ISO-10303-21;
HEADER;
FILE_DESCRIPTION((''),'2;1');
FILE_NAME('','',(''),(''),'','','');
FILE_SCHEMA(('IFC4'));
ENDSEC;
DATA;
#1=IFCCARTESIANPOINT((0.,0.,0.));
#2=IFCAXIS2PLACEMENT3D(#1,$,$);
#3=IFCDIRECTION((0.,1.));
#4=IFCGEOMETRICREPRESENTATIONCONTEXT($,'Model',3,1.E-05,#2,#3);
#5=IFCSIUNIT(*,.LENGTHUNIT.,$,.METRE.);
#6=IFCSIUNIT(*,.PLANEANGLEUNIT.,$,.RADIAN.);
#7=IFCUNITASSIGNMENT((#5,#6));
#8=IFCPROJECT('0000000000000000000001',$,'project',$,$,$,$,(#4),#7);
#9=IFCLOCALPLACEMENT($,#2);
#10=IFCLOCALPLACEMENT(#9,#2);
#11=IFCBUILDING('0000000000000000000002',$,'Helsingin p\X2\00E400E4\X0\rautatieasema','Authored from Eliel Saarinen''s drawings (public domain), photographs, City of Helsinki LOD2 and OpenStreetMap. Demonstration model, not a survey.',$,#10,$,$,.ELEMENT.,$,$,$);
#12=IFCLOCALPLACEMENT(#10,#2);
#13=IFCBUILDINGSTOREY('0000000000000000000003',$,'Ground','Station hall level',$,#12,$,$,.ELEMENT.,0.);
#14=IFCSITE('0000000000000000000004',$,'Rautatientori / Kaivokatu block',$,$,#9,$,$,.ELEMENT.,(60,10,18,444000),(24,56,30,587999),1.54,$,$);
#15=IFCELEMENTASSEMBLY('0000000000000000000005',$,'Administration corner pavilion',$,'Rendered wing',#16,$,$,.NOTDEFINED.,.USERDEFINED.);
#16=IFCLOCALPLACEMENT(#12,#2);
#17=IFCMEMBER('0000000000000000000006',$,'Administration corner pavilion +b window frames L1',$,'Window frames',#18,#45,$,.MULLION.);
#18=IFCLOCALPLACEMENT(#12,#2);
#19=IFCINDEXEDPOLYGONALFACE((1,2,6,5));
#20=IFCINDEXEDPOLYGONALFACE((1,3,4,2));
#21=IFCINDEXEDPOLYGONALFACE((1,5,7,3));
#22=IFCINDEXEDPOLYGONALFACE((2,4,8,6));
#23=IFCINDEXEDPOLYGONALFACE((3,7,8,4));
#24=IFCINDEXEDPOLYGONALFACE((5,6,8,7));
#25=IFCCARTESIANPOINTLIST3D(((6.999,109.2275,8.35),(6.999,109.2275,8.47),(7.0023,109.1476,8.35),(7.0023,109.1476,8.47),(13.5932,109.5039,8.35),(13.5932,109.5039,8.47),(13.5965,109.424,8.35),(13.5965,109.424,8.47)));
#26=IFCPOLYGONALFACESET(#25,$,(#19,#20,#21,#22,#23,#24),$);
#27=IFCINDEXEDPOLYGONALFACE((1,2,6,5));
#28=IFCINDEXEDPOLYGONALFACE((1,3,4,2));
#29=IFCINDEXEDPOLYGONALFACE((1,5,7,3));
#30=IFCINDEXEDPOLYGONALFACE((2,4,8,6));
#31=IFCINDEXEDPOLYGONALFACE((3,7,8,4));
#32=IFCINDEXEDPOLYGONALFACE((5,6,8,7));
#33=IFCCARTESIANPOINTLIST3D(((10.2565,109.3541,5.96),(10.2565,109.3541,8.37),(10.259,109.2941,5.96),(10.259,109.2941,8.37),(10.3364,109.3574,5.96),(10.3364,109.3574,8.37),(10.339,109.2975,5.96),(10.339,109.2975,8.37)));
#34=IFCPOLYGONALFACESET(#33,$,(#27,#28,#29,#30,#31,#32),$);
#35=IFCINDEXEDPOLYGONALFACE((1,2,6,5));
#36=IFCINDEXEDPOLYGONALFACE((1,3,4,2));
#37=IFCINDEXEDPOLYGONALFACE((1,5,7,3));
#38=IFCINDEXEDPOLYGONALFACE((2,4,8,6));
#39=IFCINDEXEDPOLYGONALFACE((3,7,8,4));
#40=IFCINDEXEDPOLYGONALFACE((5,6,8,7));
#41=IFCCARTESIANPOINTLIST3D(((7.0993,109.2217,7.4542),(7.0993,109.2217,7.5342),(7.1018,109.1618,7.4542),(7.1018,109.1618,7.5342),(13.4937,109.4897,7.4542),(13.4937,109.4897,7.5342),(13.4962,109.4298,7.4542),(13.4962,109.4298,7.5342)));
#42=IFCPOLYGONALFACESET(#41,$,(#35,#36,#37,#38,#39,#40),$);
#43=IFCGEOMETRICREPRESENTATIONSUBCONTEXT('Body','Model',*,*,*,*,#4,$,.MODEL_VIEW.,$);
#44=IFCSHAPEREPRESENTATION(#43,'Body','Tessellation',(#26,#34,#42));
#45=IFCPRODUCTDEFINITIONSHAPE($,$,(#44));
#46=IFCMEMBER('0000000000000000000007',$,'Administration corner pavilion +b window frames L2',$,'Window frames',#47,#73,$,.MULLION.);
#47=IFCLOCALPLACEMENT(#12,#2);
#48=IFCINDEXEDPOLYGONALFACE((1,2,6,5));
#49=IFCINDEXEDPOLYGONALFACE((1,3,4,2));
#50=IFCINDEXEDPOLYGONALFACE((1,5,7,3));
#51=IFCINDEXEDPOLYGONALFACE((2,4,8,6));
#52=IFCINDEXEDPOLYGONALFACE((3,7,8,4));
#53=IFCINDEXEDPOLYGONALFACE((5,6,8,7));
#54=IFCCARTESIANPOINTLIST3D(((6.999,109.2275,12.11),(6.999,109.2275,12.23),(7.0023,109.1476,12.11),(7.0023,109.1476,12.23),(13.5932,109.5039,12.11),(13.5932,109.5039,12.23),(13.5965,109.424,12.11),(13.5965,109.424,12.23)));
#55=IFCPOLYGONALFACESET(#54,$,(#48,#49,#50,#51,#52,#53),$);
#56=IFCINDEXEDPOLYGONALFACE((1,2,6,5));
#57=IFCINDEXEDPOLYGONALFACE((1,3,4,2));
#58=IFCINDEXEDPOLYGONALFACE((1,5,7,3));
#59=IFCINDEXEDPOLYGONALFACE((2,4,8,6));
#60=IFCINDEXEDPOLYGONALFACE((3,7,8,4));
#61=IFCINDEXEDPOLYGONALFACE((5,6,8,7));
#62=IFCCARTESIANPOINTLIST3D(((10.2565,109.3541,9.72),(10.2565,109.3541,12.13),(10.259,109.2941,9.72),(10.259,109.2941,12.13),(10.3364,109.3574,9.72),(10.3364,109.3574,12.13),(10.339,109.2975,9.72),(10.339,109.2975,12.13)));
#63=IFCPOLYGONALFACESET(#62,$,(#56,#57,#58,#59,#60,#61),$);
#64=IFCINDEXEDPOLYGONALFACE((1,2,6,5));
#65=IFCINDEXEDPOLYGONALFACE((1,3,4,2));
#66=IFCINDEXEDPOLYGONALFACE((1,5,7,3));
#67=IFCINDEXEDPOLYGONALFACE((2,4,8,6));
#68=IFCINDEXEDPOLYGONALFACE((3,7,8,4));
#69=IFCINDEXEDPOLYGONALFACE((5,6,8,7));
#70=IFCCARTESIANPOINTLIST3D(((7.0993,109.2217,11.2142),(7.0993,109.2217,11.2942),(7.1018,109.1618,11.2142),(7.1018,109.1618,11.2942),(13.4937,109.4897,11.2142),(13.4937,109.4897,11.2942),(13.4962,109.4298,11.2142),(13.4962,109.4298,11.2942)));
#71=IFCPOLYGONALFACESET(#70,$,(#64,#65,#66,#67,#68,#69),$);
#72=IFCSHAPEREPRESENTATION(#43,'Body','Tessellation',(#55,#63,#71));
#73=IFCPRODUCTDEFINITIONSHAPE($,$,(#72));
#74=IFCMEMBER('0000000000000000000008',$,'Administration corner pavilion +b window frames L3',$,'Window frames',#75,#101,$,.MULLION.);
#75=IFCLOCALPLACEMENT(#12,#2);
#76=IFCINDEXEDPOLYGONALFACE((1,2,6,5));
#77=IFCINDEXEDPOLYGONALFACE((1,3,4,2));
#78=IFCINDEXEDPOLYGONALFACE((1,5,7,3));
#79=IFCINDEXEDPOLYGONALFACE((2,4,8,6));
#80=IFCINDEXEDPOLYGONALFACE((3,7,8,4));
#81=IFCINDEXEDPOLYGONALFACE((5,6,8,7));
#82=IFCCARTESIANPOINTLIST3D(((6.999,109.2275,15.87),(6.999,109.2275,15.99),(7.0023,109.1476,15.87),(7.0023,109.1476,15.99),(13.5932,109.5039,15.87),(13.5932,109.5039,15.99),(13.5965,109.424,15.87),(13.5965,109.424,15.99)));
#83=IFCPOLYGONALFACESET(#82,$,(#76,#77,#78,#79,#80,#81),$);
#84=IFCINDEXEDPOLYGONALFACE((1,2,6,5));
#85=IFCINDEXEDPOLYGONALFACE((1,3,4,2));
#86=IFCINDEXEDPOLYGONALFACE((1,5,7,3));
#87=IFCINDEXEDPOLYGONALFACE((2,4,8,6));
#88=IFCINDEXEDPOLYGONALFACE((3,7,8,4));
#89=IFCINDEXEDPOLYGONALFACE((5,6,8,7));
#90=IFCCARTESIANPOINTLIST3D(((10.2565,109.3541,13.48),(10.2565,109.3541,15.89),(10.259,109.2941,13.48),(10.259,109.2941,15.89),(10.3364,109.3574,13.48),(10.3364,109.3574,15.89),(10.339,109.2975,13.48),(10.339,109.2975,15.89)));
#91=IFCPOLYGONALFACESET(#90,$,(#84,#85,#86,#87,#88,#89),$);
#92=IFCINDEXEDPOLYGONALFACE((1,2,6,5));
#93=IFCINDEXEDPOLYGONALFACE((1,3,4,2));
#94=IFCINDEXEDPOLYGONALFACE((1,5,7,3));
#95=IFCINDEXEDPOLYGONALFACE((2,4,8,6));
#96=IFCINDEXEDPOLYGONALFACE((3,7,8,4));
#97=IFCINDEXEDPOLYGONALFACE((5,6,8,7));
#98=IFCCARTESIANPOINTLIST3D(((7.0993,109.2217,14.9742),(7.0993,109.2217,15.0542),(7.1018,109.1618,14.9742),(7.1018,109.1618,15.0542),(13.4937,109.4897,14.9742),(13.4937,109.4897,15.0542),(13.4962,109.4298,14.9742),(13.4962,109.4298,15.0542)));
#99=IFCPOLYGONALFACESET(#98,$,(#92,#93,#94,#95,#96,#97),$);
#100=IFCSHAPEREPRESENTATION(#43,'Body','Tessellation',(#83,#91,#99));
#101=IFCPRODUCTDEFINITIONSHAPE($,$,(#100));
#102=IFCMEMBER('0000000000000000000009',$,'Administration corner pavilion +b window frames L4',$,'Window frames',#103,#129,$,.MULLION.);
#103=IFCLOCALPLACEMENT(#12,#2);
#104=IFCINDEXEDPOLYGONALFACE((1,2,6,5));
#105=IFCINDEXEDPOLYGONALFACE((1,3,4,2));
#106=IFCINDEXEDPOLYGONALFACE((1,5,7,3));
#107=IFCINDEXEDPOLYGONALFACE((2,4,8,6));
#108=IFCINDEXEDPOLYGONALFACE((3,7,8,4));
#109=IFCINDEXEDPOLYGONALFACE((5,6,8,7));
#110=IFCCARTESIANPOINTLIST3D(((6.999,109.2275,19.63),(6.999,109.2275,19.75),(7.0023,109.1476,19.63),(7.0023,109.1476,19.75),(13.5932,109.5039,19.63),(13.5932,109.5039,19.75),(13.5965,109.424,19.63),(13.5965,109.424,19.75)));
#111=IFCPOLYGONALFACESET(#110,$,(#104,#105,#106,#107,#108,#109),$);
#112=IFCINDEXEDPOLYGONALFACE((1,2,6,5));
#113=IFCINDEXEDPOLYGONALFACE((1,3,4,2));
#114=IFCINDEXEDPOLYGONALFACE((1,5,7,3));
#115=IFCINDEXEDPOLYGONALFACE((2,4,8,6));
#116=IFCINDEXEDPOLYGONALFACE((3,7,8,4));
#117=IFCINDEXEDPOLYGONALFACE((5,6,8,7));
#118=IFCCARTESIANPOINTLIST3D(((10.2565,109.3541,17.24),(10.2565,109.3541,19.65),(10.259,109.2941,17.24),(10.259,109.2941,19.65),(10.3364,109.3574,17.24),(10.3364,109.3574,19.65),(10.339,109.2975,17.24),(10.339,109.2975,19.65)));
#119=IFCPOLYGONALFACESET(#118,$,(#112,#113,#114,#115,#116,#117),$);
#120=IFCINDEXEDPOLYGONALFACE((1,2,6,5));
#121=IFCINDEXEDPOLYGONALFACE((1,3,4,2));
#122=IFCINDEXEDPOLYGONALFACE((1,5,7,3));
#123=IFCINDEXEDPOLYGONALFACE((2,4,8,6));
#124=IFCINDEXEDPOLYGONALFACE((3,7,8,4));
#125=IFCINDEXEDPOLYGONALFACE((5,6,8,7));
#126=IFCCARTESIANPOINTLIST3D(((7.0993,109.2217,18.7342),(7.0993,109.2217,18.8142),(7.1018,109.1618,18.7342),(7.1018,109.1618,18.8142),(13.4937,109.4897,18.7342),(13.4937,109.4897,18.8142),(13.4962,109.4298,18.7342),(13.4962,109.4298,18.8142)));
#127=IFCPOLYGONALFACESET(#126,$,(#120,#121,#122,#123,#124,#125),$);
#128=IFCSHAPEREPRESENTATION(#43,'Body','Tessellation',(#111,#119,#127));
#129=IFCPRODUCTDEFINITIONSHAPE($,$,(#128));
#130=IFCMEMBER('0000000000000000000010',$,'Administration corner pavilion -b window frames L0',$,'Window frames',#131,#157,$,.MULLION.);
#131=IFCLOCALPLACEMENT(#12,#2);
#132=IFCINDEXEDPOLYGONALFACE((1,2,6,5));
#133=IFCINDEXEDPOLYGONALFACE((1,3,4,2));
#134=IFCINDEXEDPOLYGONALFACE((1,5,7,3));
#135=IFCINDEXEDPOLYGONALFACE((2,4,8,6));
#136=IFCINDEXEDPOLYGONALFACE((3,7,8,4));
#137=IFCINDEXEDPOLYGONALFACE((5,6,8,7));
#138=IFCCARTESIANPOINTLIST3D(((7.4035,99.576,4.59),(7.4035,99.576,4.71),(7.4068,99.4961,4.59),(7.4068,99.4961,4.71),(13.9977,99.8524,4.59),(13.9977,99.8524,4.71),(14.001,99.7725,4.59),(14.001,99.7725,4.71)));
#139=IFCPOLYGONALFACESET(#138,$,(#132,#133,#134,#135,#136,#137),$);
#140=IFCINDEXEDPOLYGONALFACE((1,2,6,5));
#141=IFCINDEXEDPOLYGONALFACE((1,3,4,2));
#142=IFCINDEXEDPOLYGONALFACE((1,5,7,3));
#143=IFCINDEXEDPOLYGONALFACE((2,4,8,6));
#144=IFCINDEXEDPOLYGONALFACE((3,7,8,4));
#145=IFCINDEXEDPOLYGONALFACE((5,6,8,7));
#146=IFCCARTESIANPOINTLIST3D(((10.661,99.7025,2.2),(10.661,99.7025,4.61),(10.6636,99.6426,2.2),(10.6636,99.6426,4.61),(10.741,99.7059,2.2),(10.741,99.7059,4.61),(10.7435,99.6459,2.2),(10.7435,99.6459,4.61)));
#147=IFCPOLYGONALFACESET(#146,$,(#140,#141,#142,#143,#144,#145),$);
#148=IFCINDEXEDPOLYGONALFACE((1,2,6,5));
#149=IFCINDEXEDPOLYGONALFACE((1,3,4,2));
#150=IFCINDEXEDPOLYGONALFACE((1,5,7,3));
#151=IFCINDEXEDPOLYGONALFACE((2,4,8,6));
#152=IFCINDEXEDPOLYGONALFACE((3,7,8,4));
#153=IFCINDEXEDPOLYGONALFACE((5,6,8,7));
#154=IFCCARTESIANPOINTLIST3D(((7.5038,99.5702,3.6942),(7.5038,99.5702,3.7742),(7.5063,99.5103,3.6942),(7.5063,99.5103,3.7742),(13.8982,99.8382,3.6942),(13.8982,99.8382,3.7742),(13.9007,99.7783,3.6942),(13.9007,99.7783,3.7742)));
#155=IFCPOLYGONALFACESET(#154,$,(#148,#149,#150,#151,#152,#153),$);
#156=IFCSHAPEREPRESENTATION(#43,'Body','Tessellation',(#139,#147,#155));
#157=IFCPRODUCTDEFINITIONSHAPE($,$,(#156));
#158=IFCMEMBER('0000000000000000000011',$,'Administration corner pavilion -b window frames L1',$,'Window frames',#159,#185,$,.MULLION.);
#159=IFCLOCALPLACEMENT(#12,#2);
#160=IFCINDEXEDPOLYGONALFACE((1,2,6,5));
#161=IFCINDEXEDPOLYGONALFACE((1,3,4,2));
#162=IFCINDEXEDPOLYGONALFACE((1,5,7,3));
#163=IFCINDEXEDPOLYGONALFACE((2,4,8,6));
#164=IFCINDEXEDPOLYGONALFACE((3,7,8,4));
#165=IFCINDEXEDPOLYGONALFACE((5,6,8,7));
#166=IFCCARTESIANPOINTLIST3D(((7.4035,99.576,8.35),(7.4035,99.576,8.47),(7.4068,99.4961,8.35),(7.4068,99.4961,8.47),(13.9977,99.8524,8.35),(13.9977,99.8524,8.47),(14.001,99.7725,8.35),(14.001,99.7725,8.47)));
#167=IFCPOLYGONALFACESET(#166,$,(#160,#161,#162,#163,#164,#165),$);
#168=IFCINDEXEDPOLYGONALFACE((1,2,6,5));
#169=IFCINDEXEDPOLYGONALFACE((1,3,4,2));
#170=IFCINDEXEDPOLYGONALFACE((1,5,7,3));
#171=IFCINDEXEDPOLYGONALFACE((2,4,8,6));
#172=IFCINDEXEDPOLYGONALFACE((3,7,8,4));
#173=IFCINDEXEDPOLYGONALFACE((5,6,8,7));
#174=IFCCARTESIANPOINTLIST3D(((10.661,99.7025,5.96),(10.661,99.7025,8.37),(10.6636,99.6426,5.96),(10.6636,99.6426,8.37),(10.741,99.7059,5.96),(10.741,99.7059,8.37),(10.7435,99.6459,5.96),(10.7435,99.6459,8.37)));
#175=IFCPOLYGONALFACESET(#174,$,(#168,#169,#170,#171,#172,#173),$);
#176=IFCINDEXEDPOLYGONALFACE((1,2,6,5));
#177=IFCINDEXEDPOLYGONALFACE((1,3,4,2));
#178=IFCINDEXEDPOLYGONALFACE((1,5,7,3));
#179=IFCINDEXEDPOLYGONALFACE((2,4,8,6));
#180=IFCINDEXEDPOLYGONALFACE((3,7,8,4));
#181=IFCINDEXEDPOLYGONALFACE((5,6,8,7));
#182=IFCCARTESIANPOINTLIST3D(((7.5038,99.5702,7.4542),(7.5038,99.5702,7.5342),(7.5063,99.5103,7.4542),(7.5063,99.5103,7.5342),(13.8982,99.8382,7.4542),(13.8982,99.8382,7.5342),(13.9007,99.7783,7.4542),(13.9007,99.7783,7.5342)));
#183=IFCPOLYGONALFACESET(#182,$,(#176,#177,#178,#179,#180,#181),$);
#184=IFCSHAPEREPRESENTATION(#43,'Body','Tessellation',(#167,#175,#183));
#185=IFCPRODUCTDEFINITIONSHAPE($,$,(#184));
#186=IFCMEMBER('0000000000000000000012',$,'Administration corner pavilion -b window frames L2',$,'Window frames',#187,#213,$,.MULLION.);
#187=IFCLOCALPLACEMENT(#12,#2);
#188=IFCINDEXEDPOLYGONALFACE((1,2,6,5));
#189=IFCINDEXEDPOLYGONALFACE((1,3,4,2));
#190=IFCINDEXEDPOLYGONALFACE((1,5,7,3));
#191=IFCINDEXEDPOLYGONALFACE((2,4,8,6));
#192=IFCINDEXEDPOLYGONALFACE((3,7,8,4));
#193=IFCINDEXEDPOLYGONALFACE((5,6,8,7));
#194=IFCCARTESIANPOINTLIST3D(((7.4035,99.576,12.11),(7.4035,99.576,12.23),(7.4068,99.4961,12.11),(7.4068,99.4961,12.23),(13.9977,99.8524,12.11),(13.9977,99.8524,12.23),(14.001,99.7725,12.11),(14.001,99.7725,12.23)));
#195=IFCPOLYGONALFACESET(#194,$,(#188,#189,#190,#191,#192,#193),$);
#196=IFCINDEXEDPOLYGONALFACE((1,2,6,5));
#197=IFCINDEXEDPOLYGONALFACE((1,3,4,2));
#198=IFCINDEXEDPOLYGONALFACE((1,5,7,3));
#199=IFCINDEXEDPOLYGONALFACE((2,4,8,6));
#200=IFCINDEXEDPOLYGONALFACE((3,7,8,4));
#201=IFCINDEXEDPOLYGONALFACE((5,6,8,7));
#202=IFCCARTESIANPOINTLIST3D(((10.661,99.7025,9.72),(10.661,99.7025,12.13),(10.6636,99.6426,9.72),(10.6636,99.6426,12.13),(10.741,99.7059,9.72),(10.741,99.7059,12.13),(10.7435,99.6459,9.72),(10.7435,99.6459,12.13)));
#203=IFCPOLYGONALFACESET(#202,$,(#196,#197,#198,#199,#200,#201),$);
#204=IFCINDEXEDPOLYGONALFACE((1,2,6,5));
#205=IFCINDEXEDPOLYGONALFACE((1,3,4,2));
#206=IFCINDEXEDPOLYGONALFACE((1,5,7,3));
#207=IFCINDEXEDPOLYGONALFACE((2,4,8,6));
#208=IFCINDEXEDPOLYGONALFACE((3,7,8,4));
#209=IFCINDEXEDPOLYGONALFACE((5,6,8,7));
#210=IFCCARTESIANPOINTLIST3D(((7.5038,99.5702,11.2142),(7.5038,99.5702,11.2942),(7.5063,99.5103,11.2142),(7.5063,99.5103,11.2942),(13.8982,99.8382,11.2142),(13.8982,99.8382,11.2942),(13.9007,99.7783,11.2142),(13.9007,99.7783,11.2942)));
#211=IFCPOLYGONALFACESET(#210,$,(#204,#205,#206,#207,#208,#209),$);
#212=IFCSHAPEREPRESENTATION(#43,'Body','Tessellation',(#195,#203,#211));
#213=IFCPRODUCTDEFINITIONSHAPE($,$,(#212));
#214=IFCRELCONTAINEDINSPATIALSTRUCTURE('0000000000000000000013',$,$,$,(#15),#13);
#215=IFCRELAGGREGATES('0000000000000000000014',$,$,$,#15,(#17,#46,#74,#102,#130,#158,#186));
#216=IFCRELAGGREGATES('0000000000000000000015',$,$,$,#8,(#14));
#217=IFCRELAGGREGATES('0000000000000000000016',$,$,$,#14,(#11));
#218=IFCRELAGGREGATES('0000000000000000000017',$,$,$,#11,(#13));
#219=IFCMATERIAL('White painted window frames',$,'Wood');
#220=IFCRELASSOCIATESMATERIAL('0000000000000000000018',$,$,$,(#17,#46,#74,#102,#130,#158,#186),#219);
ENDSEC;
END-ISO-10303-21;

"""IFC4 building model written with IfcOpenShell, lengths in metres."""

from ifc_helpers import new_model, si_unit, direction, frame, frame_2d, origin, place, context, subcontext, project, spatial, rectangle, extrude, material, element, aggregate, save


model = new_model("IFC4")

# Units and contexts
model_context = context("Model", 3, precision=1e-05, world=origin(), true_north=direction((0.0, 1.0)))
body_context = subcontext(model_context, "Body", "Model", "MODEL_VIEW")
ifc_project = project(units=[si_unit("LENGTHUNIT", "METRE"), si_unit("PLANEANGLEUNIT", "RADIAN")], contexts=[model_context])

# Site, building, storey
site_placement = place(None, origin())
site = spatial("IfcSite", under=ifc_project, at=site_placement, Name="Rautatientori / Kaivokatu block", CompositionType="ELEMENT", RefLatitude=(60, 10, 18, 444000), RefLongitude=(24, 56, 30, 587999), RefElevation=1.54)
building_placement = place(site_placement, origin())
building = spatial("IfcBuilding", under=site, at=building_placement, Name="Helsingin päärautatieasema", Description="Authored from Eliel Saarinen's drawings (public domain), photographs, City of Helsinki LOD2 and OpenStreetMap. Demonstration model, not a survey.", CompositionType="ELEMENT")
storey_placement = place(building_placement, origin())
storey = spatial("IfcBuildingStorey", under=building, at=storey_placement, Name="Ground", Description="Station hall level", CompositionType="ELEMENT", Elevation=0.0)

# Element assembly, members
assembly_placement = place(building_placement, origin())
assembly = element("IfcElementAssembly", 1, at=assembly_placement, inside=storey, Name="Administration corner pavilion", ObjectType="Rendered wing", AssemblyPlace="NOTDEFINED", PredefinedType="USERDEFINED")
ifc_material_1 = material(Name="White painted window frames", Category="Wood")
member_1_placement = place(building_placement, origin())
member_1 = element("IfcMember", 2, at=member_1_placement, material=ifc_material_1, Name="Administration corner pavilion +b window frames L1", ObjectType="Window frames", PredefinedType="MULLION", context=body_context, shape_type="SweptSolid", body=[
    extrude(rectangle(XDim=6.6, YDim=0.08, at=frame_2d((0.0, 0.0), x_axis=(-0.999123, -0.041876))), frame((10.2977, 109.3258, 8.35)), (0.0, 0.0, 1.0), 0.12),
    extrude(rectangle(XDim=0.08, YDim=0.06, at=frame_2d((0.0, 0.0), x_axis=(-0.999123, -0.041876))), frame((10.2977, 109.3258, 5.96)), (0.0, 0.0, 1.0), 2.41),
    extrude(rectangle(XDim=6.4, YDim=0.06, at=frame_2d((0.0, 0.0), x_axis=(-0.999123, -0.041876))), frame((10.2977, 109.3258, 7.4542)), (0.0, 0.0, 1.0), 0.08),
])
member_2_placement = place(building_placement, origin())
member_2 = element("IfcMember", 3, at=member_2_placement, material=ifc_material_1, Name="Administration corner pavilion +b window frames L2", ObjectType="Window frames", PredefinedType="MULLION", context=body_context, shape_type="SweptSolid", body=[
    extrude(rectangle(XDim=6.6, YDim=0.08, at=frame_2d((0.0, 0.0), x_axis=(-0.999123, -0.041876))), frame((10.2977, 109.3258, 12.11)), (0.0, 0.0, 1.0), 0.12),
    extrude(rectangle(XDim=0.08, YDim=0.06, at=frame_2d((0.0, 0.0), x_axis=(-0.999123, -0.041876))), frame((10.2977, 109.3258, 9.72)), (0.0, 0.0, 1.0), 2.41),
    extrude(rectangle(XDim=6.4, YDim=0.06, at=frame_2d((0.0, 0.0), x_axis=(-0.999123, -0.041876))), frame((10.2977, 109.3258, 11.2142)), (0.0, 0.0, 1.0), 0.08),
])
member_3_placement = place(building_placement, origin())
member_3 = element("IfcMember", 4, at=member_3_placement, material=ifc_material_1, Name="Administration corner pavilion +b window frames L3", ObjectType="Window frames", PredefinedType="MULLION", context=body_context, shape_type="SweptSolid", body=[
    extrude(rectangle(XDim=6.6, YDim=0.08, at=frame_2d((0.0, 0.0), x_axis=(-0.999123, -0.041876))), frame((10.2977, 109.3258, 15.87)), (0.0, 0.0, 1.0), 0.12),
    extrude(rectangle(XDim=0.08, YDim=0.06, at=frame_2d((0.0, 0.0), x_axis=(-0.999123, -0.041876))), frame((10.2977, 109.3258, 13.48)), (0.0, 0.0, 1.0), 2.41),
    extrude(rectangle(XDim=6.4, YDim=0.06, at=frame_2d((0.0, 0.0), x_axis=(-0.999123, -0.041876))), frame((10.2977, 109.3258, 14.9742)), (0.0, 0.0, 1.0), 0.08),
])
member_4_placement = place(building_placement, origin())
member_4 = element("IfcMember", 5, at=member_4_placement, material=ifc_material_1, Name="Administration corner pavilion +b window frames L4", ObjectType="Window frames", PredefinedType="MULLION", context=body_context, shape_type="SweptSolid", body=[
    extrude(rectangle(XDim=6.6, YDim=0.08, at=frame_2d((0.0, 0.0), x_axis=(-0.999123, -0.041876))), frame((10.2977, 109.3258, 19.63)), (0.0, 0.0, 1.0), 0.12),
    extrude(rectangle(XDim=0.08, YDim=0.06, at=frame_2d((0.0, 0.0), x_axis=(-0.999123, -0.041876))), frame((10.2977, 109.3258, 17.24)), (0.0, 0.0, 1.0), 2.41),
    extrude(rectangle(XDim=6.4, YDim=0.06, at=frame_2d((0.0, 0.0), x_axis=(-0.999123, -0.041876))), frame((10.2977, 109.3258, 18.7342)), (0.0, 0.0, 1.0), 0.08),
])
member_5_placement = place(building_placement, origin())
member_5 = element("IfcMember", 6, at=member_5_placement, material=ifc_material_1, Name="Administration corner pavilion -b window frames L0", ObjectType="Window frames", PredefinedType="MULLION", context=body_context, shape_type="SweptSolid", body=[
    extrude(rectangle(XDim=6.6, YDim=0.08, at=frame_2d((0.0, 0.0), x_axis=(0.999123, 0.041876))), frame((10.7023, 99.6742, 4.59)), (0.0, 0.0, 1.0), 0.12),
    extrude(rectangle(XDim=0.08, YDim=0.06, at=frame_2d((0.0, 0.0), x_axis=(0.999123, 0.041876))), frame((10.7023, 99.6742, 2.2)), (0.0, 0.0, 1.0), 2.41),
    extrude(rectangle(XDim=6.4, YDim=0.06, at=frame_2d((0.0, 0.0), x_axis=(0.999123, 0.041876))), frame((10.7023, 99.6742, 3.6942)), (0.0, 0.0, 1.0), 0.08),
])
member_6_placement = place(building_placement, origin())
member_6 = element("IfcMember", 7, at=member_6_placement, material=ifc_material_1, Name="Administration corner pavilion -b window frames L1", ObjectType="Window frames", PredefinedType="MULLION", context=body_context, shape_type="SweptSolid", body=[
    extrude(rectangle(XDim=6.6, YDim=0.08, at=frame_2d((0.0, 0.0), x_axis=(0.999123, 0.041876))), frame((10.7023, 99.6742, 8.35)), (0.0, 0.0, 1.0), 0.12),
    extrude(rectangle(XDim=0.08, YDim=0.06, at=frame_2d((0.0, 0.0), x_axis=(0.999123, 0.041876))), frame((10.7023, 99.6742, 5.96)), (0.0, 0.0, 1.0), 2.41),
    extrude(rectangle(XDim=6.4, YDim=0.06, at=frame_2d((0.0, 0.0), x_axis=(0.999123, 0.041876))), frame((10.7023, 99.6742, 7.4542)), (0.0, 0.0, 1.0), 0.08),
])
member_7_placement = place(building_placement, origin())
member_7 = element("IfcMember", 8, at=member_7_placement, material=ifc_material_1, Name="Administration corner pavilion -b window frames L2", ObjectType="Window frames", PredefinedType="MULLION", context=body_context, shape_type="SweptSolid", body=[
    extrude(rectangle(XDim=6.6, YDim=0.08, at=frame_2d((0.0, 0.0), x_axis=(0.999123, 0.041876))), frame((10.7023, 99.6742, 12.11)), (0.0, 0.0, 1.0), 0.12),
    extrude(rectangle(XDim=0.08, YDim=0.06, at=frame_2d((0.0, 0.0), x_axis=(0.999123, 0.041876))), frame((10.7023, 99.6742, 9.72)), (0.0, 0.0, 1.0), 2.41),
    extrude(rectangle(XDim=6.4, YDim=0.06, at=frame_2d((0.0, 0.0), x_axis=(0.999123, 0.041876))), frame((10.7023, 99.6742, 11.2142)), (0.0, 0.0, 1.0), 0.08),
])
aggregate(assembly, [member_1, member_2, member_3, member_4, member_5, member_6, member_7])

save(model, "model.ifc")
